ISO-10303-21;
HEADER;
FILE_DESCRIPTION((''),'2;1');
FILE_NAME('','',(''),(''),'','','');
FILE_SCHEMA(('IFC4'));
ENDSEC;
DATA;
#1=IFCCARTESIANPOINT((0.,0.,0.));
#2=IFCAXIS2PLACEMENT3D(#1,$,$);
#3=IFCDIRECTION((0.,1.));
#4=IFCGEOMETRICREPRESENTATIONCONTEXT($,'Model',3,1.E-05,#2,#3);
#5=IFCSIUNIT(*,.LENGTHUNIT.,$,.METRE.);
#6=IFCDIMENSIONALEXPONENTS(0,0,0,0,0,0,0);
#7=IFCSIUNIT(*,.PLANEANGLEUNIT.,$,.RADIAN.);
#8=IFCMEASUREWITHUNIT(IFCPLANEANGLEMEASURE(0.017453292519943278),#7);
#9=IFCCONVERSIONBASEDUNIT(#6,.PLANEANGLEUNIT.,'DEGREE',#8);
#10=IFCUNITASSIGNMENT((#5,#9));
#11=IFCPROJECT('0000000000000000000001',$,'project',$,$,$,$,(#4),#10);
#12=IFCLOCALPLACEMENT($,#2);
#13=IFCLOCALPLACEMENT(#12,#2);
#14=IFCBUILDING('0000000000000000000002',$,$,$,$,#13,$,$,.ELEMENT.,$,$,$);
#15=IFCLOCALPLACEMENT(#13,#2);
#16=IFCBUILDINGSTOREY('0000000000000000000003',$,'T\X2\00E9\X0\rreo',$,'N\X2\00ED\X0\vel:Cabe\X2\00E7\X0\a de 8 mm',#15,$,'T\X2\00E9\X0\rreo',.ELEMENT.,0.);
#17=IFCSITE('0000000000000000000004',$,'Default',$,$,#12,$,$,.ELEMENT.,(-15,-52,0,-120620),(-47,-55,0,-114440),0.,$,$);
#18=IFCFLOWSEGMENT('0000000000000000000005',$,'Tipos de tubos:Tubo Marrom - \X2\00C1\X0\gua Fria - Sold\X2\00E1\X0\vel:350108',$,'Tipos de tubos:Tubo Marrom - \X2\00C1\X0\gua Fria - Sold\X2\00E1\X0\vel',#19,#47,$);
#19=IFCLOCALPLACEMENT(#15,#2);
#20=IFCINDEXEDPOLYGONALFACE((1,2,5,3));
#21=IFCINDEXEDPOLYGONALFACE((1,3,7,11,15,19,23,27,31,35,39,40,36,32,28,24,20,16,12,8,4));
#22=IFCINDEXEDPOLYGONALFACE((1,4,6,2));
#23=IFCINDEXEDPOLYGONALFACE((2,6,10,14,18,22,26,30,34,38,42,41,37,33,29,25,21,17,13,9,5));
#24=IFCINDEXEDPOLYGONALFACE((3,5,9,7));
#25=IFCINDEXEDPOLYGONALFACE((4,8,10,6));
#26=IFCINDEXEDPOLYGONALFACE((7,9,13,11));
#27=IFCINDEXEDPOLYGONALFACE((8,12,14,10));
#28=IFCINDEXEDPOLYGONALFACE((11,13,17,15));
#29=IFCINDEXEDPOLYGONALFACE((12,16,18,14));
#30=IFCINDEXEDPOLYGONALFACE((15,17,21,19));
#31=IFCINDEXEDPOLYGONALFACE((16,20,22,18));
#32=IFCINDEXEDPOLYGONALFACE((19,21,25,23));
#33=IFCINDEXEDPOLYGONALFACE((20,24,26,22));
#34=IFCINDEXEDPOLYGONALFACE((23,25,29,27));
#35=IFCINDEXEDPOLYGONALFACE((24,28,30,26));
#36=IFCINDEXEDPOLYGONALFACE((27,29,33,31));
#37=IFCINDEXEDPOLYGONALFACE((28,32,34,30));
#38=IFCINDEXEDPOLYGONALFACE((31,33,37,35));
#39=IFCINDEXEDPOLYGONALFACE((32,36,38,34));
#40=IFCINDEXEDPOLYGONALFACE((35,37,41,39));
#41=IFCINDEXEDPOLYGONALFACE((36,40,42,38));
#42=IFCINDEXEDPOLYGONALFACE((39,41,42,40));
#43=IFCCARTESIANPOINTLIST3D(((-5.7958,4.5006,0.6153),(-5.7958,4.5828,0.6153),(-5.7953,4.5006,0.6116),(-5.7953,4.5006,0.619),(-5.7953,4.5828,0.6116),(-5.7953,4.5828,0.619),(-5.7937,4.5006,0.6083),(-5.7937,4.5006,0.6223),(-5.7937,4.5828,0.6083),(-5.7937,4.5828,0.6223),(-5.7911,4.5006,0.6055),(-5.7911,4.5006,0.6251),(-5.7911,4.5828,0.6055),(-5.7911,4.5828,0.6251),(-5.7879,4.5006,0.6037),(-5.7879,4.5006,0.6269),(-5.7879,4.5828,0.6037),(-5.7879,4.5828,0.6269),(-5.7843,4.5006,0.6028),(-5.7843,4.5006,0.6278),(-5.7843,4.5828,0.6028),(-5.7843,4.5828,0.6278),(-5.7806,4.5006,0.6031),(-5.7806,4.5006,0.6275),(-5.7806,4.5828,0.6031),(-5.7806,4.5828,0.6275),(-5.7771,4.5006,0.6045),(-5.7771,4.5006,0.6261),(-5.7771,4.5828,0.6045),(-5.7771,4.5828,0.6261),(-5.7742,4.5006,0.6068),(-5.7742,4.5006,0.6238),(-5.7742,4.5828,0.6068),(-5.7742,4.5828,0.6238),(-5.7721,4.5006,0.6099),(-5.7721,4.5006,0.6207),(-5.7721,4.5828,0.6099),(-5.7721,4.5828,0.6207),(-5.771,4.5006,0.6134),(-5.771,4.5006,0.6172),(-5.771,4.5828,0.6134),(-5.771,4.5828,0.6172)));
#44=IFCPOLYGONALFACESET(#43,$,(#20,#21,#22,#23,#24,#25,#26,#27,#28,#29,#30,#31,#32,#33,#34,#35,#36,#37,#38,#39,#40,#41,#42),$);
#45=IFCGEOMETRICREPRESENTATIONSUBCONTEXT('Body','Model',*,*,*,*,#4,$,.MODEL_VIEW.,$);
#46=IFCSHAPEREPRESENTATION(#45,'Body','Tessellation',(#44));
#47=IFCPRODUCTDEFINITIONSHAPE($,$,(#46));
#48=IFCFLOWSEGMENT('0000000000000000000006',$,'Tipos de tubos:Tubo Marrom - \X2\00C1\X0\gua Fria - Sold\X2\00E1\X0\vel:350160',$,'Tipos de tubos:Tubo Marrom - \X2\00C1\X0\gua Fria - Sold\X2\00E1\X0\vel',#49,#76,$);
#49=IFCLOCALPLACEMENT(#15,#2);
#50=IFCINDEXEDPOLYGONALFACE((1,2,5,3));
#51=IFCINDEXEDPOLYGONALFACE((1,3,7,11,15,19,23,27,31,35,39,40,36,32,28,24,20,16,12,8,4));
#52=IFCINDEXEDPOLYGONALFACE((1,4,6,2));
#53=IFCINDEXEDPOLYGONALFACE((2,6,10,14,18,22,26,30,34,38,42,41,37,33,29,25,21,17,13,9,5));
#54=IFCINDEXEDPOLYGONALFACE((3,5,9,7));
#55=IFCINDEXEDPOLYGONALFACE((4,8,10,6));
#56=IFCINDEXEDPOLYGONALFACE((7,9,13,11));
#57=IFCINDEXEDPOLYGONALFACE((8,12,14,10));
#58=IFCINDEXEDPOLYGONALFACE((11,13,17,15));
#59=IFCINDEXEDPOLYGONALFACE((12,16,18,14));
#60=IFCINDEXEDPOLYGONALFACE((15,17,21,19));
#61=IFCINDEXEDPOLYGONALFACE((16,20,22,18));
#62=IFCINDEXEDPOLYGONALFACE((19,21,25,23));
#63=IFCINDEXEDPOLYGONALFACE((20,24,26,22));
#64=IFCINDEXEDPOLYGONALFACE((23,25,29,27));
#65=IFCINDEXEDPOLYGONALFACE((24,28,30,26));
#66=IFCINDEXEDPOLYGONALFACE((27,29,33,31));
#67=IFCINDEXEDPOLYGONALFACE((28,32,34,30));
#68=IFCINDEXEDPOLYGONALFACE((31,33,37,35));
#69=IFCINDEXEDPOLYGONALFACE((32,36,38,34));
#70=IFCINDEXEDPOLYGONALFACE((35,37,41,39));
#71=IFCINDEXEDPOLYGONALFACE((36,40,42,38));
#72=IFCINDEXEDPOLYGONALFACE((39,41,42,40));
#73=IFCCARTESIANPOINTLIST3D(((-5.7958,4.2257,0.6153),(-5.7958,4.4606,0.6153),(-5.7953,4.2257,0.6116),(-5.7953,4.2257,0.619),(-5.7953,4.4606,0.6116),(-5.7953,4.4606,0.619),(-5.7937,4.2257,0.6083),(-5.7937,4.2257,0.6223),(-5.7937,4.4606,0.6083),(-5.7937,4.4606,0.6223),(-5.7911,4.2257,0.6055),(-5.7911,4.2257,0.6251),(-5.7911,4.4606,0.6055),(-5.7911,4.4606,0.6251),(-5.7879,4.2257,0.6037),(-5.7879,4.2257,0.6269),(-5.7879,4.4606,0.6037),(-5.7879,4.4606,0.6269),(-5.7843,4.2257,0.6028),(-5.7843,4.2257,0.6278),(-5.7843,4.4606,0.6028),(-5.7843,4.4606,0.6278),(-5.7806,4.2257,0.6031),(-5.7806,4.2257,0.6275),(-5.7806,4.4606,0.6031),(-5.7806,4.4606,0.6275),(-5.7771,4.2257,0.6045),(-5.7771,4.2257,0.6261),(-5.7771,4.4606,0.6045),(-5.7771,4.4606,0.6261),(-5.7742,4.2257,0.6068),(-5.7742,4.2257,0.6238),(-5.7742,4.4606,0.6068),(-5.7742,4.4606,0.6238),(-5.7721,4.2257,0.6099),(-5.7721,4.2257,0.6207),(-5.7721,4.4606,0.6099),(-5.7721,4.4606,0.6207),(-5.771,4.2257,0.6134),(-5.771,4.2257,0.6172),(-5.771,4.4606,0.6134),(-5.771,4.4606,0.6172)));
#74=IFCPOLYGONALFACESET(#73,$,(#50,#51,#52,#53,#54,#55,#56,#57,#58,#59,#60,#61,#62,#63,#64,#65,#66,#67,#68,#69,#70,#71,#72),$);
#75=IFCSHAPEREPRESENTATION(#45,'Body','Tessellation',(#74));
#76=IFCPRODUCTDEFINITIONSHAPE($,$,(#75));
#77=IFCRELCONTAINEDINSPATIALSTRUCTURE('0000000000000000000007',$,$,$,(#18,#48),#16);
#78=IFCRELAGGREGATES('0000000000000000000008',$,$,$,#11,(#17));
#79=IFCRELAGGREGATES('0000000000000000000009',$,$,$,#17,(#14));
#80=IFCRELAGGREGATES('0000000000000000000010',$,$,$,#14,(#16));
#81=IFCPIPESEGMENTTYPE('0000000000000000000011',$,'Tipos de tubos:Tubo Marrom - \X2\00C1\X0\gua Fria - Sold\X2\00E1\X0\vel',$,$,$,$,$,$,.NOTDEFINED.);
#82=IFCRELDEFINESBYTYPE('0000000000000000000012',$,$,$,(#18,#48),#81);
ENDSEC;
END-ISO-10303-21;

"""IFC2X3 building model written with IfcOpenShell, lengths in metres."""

from ifc_helpers import new_model, entity, si_unit, converted_unit, direction, frame, origin, origin_2d_with_axis, place, context, subcontext, project, spatial, circle, extrude, type_object, element, save


model = new_model("IFC2X3")

# Units and contexts
model_context = context("Model", 3, precision=1e-05, world=origin(), true_north=direction((0.0, 1.0)))
body_context = subcontext(model_context, "Body", "Model", "MODEL_VIEW")
ifc_project = project(units=[si_unit("LENGTHUNIT", "METRE"), converted_unit("PLANEANGLEUNIT", "DEGREE", entity("IfcPlaneAngleMeasure", 0.017453292519943278), si_unit("PLANEANGLEUNIT", "RADIAN"), dimensions=[0, 0, 0, 0, 0, 0, 0])], contexts=[model_context])

# Site, building, storey
site_placement = place(None, origin())
site = spatial("IfcSite", under=ifc_project, at=site_placement, Name="Default", CompositionType="ELEMENT", RefLatitude=(-15, -52, 0, -120620), RefLongitude=(-47, -55, 0, -114440), RefElevation=0.0)
building_placement = place(site_placement, origin())
building = spatial("IfcBuilding", under=site, at=building_placement, CompositionType="ELEMENT")
storey_placement = place(building_placement, origin())
storey = spatial("IfcBuildingStorey", under=building, at=storey_placement, Name="Térreo", ObjectType="Nível:Cabeça de 8 mm", LongName="Térreo", CompositionType="ELEMENT", Elevation=0.0)

# Flow segments
pipe_segment_type = type_object("IfcPipeSegmentType", Name="Tipos de tubos:Tubo Marrom - Água Fria - Soldável", PredefinedType="NOTDEFINED")
flow_segment_1_placement = place(storey_placement, origin())
element("IfcFlowSegment", 1, at=flow_segment_1_placement, inside=storey, type_object=pipe_segment_type, Name="Tipos de tubos:Tubo Marrom - Água Fria - Soldável:350108", ObjectType="Tipos de tubos:Tubo Marrom - Água Fria - Soldável", context=body_context, shape_type="SweptSolid", body=[
    extrude(circle(Radius=0.0125, at=origin_2d_with_axis()), frame((-5.7833, 4.5006, 0.6153), z_axis=(0.0, 1.0, 0.0), x_axis=(-1.0, 0.0, 0.0)), (0.0, 0.0, 1.0), 0.0822),
])
flow_segment_2_placement = place(storey_placement, origin())
element("IfcFlowSegment", 2, at=flow_segment_2_placement, inside=storey, type_object=pipe_segment_type, Name="Tipos de tubos:Tubo Marrom - Água Fria - Soldável:350160", ObjectType="Tipos de tubos:Tubo Marrom - Água Fria - Soldável", context=body_context, shape_type="SweptSolid", body=[
    extrude(circle(Radius=0.0125, at=origin_2d_with_axis()), frame((-5.7833, 4.2257, 0.6153), z_axis=(0.0, 1.0, 0.0), x_axis=(-1.0, 0.0, 0.0)), (0.0, 0.0, 1.0), 0.2349),
])

save(model, "model.ifc")
